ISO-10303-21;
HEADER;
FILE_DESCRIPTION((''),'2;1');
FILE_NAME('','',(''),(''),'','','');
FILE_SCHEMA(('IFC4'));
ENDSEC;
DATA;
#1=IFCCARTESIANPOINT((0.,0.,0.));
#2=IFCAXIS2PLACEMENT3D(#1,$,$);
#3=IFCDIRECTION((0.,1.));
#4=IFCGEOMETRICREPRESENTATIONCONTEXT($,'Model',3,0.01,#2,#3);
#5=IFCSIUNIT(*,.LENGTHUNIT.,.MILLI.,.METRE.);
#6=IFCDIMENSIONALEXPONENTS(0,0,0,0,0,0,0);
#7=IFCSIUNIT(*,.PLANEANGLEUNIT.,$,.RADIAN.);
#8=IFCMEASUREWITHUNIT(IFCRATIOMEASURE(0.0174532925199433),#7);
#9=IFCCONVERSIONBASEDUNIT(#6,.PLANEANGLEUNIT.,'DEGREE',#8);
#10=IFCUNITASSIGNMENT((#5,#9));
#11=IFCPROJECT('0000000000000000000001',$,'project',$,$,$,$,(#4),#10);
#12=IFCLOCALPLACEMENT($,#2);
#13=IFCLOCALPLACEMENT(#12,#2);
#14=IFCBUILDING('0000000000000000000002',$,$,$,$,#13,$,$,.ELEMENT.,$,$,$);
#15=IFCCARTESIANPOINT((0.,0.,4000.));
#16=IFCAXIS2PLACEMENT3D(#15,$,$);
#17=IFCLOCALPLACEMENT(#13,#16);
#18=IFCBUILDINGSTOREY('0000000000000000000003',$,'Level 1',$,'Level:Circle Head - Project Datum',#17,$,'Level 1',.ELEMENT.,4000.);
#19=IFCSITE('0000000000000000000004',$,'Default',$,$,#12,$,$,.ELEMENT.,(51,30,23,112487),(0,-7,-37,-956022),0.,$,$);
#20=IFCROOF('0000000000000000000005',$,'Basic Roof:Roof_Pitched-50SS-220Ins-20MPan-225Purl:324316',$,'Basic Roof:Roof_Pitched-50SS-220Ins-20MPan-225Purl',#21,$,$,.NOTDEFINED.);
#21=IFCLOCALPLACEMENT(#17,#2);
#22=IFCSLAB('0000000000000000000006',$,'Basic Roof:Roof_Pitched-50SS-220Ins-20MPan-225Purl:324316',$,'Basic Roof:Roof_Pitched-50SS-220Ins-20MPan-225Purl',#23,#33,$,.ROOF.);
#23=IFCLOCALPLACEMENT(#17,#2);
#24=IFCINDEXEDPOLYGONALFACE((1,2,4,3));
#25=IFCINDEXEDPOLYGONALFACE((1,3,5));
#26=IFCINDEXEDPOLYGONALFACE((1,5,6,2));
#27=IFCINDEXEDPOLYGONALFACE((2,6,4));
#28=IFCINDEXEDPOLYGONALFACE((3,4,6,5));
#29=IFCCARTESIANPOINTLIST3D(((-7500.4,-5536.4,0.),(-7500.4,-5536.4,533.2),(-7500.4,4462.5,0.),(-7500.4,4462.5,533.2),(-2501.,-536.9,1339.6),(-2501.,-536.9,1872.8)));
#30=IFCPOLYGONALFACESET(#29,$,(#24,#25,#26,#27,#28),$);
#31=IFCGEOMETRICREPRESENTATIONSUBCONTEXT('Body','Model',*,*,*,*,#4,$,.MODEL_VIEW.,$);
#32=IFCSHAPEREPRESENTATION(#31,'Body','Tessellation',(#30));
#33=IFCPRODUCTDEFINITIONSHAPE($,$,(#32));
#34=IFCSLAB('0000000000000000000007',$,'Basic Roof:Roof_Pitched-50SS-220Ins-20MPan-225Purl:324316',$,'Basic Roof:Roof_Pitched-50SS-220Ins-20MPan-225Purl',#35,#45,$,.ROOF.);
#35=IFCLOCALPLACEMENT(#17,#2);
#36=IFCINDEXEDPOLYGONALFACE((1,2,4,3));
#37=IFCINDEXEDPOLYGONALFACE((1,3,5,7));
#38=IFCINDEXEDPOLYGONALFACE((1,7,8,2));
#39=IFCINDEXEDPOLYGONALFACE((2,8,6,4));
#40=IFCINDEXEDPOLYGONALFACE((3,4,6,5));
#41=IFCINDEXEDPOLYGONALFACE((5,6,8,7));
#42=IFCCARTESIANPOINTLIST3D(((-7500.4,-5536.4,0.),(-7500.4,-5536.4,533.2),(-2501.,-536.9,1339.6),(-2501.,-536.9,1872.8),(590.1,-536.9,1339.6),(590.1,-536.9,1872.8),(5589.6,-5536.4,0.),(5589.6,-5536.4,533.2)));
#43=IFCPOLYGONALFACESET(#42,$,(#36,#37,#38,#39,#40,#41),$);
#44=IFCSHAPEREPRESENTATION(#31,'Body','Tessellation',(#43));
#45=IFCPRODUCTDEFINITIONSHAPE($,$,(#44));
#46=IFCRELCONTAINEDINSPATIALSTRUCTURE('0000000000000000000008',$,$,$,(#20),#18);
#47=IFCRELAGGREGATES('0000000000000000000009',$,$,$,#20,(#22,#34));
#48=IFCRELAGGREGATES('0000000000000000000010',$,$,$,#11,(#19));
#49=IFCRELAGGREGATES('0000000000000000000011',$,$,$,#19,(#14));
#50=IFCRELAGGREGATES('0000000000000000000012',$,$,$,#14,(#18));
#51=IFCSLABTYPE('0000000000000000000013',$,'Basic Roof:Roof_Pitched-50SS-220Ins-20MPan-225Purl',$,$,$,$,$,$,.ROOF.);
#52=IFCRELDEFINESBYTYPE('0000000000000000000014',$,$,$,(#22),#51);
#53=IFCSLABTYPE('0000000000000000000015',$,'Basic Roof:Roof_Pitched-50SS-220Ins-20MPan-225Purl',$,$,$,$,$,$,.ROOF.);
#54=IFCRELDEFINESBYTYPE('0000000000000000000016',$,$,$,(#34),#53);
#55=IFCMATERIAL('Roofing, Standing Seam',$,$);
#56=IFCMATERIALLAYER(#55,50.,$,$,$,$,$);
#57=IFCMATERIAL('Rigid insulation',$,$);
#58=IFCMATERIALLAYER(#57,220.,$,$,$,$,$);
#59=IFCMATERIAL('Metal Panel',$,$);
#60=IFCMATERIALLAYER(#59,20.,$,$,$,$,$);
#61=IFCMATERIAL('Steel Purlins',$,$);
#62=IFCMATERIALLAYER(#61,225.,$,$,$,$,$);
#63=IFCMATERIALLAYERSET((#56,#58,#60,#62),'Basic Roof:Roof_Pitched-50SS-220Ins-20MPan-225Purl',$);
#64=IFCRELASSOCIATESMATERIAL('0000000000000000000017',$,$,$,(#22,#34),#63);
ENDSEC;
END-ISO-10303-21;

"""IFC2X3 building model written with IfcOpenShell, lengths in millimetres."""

from ifc_helpers import new_model, entity, si_unit, converted_unit, direction, frame, origin, place, context, subcontext, project, spatial, polyline, outline, extrude, material, layer, layer_set, type_object, element, aggregate, save


model = new_model("IFC2X3")

# Units and contexts
model_context = context("Model", 3, precision=0.01, world=origin(), true_north=direction((0.0, 1.0)))
body_context = subcontext(model_context, "Body", "Model", "MODEL_VIEW")
ifc_project = project(units=[si_unit("LENGTHUNIT", "METRE", prefix="MILLI"), converted_unit("PLANEANGLEUNIT", "DEGREE", entity("IfcRatioMeasure", 0.0174532925199433), si_unit("PLANEANGLEUNIT", "RADIAN"), dimensions=[0, 0, 0, 0, 0, 0, 0])], contexts=[model_context])

# Site, building, storey
site_placement = place(None, origin())
site = spatial("IfcSite", under=ifc_project, at=site_placement, Name="Default", CompositionType="ELEMENT", RefLatitude=(51, 30, 23, 112487), RefLongitude=(0, -7, -37, -956022), RefElevation=0.0)
building_placement = place(site_placement, origin())
building = spatial("IfcBuilding", under=site, at=building_placement, CompositionType="ELEMENT")
storey_placement = place(building_placement, frame((0.0, 0.0, 4000.0)))
storey = spatial("IfcBuildingStorey", under=building, at=storey_placement, Name="Level 1", ObjectType="Level:Circle Head - Project Datum", LongName="Level 1", CompositionType="ELEMENT", Elevation=4000.0)

# Roof, slabs
roof_placement = place(storey_placement, frame((-7500.4, -5536.4, 0.0)))
roof = element("IfcRoof", 1, at=roof_placement, inside=storey, Name="Basic Roof:Roof_Pitched-50SS-220Ins-20MPan-225Purl:324316", ObjectType="Basic Roof:Roof_Pitched-50SS-220Ins-20MPan-225Purl", ShapeType="NOTDEFINED")
ifc_material_1 = material(Name="Roofing, Standing Seam")
ifc_layer_1 = layer(ifc_material_1, 50.0)
ifc_material_2 = material(Name="Rigid insulation")
ifc_layer_2 = layer(ifc_material_2, 220.0)
ifc_material_3 = material(Name="Metal Panel")
ifc_layer_3 = layer(ifc_material_3, 20.0)
ifc_material_4 = material(Name="Steel Purlins")
ifc_layer_4 = layer(ifc_material_4, 225.0)
ifc_layer_set = layer_set([ifc_layer_1, ifc_layer_2, ifc_layer_3, ifc_layer_4], Name="Basic Roof:Roof_Pitched-50SS-220Ins-20MPan-225Purl")
slab_type_1 = type_object("IfcSlabType", Name="Basic Roof:Roof_Pitched-50SS-220Ins-20MPan-225Purl", PredefinedType="ROOF")
slab_1_placement = place(roof_placement, origin())
slab_1 = element("IfcSlab", 2, at=slab_1_placement, type_object=slab_type_1, material=ifc_layer_set, Name="Basic Roof:Roof_Pitched-50SS-220Ins-20MPan-225Purl:324316", ObjectType="Basic Roof:Roof_Pitched-50SS-220Ins-20MPan-225Purl", PredefinedType="ROOF", context=body_context, shape_type="SweptSolid", body=[
    extrude(outline(polyline([(-2587.9, 4999.5), (-2587.9, -4999.5), (2587.9, 0.0), (-2587.9, 4999.5)])), frame((2499.7, 4999.5, 669.8), z_axis=(-0.258819, 0.0, 0.965926), x_axis=(0.965926, 0.0, 0.258819)), (0.258819, 0.0, 0.965926), 533.2),
])
slab_type_2 = type_object("IfcSlabType", Name="Basic Roof:Roof_Pitched-50SS-220Ins-20MPan-225Purl", PredefinedType="ROOF")
slab_2_placement = place(roof_placement, origin())
slab_2 = element("IfcSlab", 3, at=slab_2_placement, type_object=slab_type_2, material=ifc_layer_set, Name="Basic Roof:Roof_Pitched-50SS-220Ins-20MPan-225Purl:324316", ObjectType="Basic Roof:Roof_Pitched-50SS-220Ins-20MPan-225Purl", PredefinedType="ROOF", context=body_context, shape_type="SweptSolid", body=[
    extrude(outline(polyline([(-6545.0, -2587.9), (6545.0, -2587.9), (1545.5, 2587.9), (-1545.5, 2587.9), (-6545.0, -2587.9)])), frame((6545.0, 2499.7, 669.8), z_axis=(0.0, -0.258819, 0.965926), x_axis=(1.0, 0.0, 0.0)), (0.0, 0.258819, 0.965926), 533.2),
])
aggregate(roof, [slab_1, slab_2])

save(model, "model.ifc")
